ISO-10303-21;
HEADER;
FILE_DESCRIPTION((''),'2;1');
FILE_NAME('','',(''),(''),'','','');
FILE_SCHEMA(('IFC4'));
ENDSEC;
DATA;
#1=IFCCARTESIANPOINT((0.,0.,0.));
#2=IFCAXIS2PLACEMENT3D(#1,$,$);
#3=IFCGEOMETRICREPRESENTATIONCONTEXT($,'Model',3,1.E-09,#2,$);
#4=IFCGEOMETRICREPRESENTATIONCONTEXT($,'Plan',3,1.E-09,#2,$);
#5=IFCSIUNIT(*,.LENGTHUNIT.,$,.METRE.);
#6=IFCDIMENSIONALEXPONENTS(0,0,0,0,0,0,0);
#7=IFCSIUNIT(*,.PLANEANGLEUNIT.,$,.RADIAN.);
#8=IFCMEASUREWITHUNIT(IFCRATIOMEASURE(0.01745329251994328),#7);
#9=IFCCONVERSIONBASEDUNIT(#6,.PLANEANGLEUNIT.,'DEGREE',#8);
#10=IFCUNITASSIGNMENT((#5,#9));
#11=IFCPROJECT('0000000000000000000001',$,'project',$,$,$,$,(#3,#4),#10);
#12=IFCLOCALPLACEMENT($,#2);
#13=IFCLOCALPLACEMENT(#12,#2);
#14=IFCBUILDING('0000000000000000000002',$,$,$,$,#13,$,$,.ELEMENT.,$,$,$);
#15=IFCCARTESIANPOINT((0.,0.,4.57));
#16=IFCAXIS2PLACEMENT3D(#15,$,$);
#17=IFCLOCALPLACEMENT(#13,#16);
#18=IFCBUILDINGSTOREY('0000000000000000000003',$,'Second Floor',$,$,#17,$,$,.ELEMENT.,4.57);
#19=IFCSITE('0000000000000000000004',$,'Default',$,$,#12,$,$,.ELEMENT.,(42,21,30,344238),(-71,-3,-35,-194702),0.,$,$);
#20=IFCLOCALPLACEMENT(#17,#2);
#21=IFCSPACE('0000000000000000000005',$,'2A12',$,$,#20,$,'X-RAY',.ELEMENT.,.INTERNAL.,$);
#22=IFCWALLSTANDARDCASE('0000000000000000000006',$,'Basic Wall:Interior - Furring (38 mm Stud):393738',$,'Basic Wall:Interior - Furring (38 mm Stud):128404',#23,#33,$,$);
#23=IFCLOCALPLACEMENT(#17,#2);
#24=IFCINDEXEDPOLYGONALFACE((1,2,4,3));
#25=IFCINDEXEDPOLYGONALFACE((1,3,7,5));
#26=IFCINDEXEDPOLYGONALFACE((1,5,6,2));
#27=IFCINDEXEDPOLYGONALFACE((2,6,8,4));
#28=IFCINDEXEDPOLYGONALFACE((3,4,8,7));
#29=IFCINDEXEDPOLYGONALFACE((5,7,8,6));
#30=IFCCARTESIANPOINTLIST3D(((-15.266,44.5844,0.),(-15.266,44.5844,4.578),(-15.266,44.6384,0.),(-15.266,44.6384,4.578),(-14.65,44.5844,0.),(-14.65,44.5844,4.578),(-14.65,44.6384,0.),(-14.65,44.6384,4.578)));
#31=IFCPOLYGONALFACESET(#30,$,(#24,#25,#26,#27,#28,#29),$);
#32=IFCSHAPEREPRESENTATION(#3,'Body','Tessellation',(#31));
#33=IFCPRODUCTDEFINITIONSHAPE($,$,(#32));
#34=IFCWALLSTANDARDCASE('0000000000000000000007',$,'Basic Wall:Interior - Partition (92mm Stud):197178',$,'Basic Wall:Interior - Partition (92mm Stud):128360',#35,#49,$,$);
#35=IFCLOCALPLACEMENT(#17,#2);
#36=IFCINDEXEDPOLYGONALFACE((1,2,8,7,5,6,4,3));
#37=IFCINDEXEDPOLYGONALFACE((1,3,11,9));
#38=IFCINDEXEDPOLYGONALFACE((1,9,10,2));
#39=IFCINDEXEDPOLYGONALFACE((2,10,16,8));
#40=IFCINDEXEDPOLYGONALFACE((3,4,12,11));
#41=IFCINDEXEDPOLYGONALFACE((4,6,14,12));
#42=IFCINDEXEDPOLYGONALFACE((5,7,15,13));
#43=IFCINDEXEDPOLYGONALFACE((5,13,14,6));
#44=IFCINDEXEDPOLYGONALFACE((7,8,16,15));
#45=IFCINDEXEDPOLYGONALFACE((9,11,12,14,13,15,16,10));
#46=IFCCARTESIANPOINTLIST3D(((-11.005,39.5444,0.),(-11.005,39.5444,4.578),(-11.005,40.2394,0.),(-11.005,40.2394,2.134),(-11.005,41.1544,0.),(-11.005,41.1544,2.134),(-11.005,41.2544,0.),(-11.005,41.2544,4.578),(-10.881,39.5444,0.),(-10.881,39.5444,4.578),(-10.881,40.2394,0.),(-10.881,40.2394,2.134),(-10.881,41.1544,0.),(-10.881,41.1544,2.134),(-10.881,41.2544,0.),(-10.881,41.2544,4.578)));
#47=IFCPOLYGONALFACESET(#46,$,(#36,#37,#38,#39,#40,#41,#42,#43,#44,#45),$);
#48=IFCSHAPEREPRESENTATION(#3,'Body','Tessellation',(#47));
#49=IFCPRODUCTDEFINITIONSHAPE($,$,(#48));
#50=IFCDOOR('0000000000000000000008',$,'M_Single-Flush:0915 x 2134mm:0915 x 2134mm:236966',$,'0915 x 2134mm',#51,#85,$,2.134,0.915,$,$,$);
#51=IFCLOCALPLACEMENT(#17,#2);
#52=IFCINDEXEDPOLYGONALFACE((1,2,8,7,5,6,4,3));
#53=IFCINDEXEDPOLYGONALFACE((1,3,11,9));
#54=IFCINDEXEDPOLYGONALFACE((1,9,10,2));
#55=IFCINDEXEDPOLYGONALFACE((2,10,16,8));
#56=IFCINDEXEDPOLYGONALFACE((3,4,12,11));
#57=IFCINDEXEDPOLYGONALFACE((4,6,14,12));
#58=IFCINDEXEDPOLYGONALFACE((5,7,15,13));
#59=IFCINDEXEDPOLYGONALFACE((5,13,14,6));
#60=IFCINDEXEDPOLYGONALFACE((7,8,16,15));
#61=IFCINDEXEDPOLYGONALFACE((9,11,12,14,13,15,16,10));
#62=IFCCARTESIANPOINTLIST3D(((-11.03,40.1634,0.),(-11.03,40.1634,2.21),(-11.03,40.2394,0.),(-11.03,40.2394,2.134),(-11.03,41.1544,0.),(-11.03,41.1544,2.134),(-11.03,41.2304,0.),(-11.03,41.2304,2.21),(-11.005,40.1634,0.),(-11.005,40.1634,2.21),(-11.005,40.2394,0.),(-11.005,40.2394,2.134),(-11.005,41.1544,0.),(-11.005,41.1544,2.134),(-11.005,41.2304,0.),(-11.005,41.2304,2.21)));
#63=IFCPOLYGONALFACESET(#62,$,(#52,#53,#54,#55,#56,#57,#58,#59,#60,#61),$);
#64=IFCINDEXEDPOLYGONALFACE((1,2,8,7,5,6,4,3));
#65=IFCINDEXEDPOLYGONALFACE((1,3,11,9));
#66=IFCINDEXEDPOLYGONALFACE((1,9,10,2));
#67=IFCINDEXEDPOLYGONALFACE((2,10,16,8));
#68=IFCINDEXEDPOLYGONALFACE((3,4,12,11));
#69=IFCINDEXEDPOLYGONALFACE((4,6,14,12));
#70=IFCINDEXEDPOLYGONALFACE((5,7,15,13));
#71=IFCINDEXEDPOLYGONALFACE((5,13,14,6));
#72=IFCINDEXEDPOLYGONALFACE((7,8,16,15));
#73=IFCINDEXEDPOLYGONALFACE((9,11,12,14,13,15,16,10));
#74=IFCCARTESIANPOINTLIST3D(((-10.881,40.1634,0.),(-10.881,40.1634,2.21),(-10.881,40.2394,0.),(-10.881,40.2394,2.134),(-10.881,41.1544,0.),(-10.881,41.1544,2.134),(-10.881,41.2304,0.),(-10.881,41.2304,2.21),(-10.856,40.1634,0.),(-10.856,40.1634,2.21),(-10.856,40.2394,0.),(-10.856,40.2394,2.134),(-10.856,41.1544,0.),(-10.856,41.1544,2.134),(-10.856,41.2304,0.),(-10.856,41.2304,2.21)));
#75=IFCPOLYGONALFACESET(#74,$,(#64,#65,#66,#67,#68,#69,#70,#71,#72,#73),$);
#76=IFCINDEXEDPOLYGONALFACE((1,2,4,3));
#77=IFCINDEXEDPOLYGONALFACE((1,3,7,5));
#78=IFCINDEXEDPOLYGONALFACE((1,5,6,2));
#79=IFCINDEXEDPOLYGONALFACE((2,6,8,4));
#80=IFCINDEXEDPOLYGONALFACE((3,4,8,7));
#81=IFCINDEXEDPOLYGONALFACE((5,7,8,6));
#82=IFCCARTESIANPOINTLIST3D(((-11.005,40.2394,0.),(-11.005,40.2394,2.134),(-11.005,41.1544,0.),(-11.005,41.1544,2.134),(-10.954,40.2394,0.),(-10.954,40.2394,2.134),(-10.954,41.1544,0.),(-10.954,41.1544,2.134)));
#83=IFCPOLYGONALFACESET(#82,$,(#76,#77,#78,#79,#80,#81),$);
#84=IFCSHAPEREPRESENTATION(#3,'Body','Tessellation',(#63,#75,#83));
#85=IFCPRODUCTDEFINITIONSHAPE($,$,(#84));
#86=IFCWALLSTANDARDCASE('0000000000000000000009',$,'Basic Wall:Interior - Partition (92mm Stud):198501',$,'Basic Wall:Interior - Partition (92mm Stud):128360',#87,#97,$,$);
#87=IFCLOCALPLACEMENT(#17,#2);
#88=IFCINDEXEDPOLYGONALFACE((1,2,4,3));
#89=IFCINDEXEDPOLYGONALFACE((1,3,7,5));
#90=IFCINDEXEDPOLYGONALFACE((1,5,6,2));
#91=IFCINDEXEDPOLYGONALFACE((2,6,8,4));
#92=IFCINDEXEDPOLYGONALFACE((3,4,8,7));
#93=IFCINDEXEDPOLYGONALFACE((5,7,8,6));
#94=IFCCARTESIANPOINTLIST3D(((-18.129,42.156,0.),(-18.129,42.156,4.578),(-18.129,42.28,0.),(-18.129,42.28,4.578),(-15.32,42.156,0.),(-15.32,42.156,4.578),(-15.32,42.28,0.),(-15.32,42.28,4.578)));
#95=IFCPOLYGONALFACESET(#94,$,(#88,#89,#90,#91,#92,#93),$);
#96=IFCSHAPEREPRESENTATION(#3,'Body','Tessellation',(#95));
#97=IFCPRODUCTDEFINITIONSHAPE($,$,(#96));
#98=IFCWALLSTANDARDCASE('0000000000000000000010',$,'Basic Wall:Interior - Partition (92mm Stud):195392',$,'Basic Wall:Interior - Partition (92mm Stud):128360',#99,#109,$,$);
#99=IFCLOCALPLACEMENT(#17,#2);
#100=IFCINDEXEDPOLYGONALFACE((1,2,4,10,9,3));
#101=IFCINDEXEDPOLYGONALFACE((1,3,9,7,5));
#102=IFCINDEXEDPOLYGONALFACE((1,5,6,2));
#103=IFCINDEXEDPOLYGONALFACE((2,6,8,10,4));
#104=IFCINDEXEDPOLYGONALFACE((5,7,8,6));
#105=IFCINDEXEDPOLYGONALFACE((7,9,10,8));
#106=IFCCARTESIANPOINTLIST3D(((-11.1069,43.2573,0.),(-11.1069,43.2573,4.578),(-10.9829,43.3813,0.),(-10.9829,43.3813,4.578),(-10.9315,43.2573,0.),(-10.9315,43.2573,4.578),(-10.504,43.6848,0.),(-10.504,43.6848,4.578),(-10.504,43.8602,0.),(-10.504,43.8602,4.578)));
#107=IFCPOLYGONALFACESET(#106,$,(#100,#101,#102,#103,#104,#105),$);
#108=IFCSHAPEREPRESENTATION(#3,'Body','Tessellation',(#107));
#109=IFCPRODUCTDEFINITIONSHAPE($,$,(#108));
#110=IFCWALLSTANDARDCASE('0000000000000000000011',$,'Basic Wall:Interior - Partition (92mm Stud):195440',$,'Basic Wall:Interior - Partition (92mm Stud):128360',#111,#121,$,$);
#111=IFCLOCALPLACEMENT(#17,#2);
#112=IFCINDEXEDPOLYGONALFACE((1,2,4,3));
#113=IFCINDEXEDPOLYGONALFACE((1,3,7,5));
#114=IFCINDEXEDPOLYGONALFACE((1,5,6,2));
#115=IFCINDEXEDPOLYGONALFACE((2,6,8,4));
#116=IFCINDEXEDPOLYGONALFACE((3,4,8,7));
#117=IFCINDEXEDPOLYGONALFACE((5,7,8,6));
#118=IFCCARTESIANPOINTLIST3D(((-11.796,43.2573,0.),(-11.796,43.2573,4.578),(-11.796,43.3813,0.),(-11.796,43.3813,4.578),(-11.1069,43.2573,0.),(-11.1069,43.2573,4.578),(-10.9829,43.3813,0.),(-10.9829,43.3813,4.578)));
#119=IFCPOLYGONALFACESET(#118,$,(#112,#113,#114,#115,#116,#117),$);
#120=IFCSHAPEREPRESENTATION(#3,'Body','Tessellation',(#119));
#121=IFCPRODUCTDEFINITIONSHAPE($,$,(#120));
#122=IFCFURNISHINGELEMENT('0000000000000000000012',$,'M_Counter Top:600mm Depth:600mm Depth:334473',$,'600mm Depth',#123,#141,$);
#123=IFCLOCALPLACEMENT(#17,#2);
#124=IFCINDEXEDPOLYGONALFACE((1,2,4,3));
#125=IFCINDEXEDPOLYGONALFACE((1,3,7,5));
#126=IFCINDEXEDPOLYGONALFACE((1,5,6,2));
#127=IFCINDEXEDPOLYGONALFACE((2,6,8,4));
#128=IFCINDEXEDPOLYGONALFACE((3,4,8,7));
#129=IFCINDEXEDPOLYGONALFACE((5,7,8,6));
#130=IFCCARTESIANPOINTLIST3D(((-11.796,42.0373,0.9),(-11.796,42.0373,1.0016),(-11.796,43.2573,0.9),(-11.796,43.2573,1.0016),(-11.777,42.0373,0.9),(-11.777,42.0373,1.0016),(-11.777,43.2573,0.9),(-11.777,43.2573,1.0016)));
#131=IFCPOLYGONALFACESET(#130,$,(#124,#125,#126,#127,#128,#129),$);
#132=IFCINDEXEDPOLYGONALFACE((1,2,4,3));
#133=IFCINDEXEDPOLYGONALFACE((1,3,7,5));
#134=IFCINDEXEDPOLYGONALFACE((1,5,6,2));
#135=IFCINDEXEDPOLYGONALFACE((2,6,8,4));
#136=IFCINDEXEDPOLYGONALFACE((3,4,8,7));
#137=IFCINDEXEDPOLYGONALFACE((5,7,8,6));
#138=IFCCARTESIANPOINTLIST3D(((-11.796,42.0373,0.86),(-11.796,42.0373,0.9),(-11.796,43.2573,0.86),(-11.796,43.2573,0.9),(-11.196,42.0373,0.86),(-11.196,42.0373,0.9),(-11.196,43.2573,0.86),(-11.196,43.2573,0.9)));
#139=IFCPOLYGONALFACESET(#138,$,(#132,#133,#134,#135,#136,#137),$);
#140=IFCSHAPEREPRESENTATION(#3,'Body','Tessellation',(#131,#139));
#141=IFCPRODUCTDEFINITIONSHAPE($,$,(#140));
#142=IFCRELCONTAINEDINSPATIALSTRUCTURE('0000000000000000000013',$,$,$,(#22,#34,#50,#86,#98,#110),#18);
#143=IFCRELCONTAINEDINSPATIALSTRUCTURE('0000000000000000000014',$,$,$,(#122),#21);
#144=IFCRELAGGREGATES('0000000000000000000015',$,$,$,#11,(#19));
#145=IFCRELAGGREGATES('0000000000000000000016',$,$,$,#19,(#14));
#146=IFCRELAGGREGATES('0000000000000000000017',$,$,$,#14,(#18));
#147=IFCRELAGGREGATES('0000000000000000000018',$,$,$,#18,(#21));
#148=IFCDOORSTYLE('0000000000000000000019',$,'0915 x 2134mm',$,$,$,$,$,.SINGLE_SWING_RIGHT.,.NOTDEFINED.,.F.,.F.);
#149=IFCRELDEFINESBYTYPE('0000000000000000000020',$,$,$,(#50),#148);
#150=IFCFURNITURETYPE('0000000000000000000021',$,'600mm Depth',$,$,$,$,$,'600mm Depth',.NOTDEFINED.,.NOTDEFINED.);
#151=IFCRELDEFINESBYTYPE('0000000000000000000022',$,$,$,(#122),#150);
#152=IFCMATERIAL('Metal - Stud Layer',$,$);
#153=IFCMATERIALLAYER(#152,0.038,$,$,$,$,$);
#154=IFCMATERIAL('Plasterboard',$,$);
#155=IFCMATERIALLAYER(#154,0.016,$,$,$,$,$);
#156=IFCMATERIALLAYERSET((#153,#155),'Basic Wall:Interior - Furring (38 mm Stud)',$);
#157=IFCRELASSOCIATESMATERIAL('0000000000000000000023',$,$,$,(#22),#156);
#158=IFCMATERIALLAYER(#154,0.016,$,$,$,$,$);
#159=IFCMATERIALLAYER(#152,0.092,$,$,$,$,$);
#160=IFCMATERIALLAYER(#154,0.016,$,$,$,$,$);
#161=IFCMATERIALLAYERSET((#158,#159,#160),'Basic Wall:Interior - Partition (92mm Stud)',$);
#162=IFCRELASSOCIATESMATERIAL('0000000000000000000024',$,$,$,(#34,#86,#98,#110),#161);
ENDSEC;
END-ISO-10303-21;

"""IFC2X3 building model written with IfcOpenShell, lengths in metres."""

from ifc_helpers import new_model, entity, si_unit, converted_unit, frame, frame_2d, origin, origin_2d_with_axis, place, context, project, spatial, polyline, rectangle, outline, extrude, source, transform, mapped, material, layer, layer_set, layer_usage, type_object, type_shapes, element, fill, save


model = new_model("IFC2X3")

# Units and contexts
model_context = context("Model", 3, precision=1e-09, world=origin())
plan_context = context("Plan", 3, precision=1e-09, world=origin())
ifc_project = project(units=[si_unit("LENGTHUNIT", "METRE"), converted_unit("PLANEANGLEUNIT", "DEGREE", entity("IfcRatioMeasure", 0.01745329251994328), si_unit("PLANEANGLEUNIT", "RADIAN"), dimensions=[0, 0, 0, 0, 0, 0, 0])], contexts=[model_context, plan_context])

# Site, building, storey
site_placement = place(None, origin())
site = spatial("IfcSite", under=ifc_project, at=site_placement, Name="Default", CompositionType="ELEMENT", RefLatitude=(42, 21, 30, 344238), RefLongitude=(-71, -3, -35, -194702), RefElevation=0.0)
building_placement = place(site_placement, origin())
building = spatial("IfcBuilding", under=site, at=building_placement, CompositionType="ELEMENT")
storey_placement = place(building_placement, frame((0.0, 0.0, 4.57)))
storey = spatial("IfcBuildingStorey", under=building, at=storey_placement, Name="Second Floor", CompositionType="ELEMENT", Elevation=4.57)

# Shared definitions
ifc_material_1 = material(Name="Plasterboard")
ifc_layer_1 = layer(ifc_material_1, 0.016)
ifc_material_2 = material(Name="Metal - Stud Layer")
ifc_layer_2 = layer(ifc_material_2, 0.092)
ifc_layer_3 = layer(ifc_material_1, 0.016)
ifc_layer_set_1 = layer_set([ifc_layer_1, ifc_layer_2, ifc_layer_3], Name="Basic Wall:Interior - Partition (92mm Stud)")
ifc_layer_usage_1 = layer_usage(ifc_layer_set_1, "AXIS2", "NEGATIVE", 0.062)

# Shared definitions
ifc_layer_4 = layer(ifc_material_2, 0.038)
ifc_layer_5 = layer(ifc_material_1, 0.016)
ifc_layer_set_2 = layer_set([ifc_layer_4, ifc_layer_5], Name="Basic Wall:Interior - Furring (38 mm Stud)")
ifc_layer_usage_2 = layer_usage(ifc_layer_set_2, "AXIS2", "POSITIVE", -0.027)

# Shared definitions
door_style_1 = type_object("IfcDoorStyle", Name="0915 x 2134mm", ConstructionType="NOTDEFINED", OperationType="SINGLE_SWING_RIGHT", ParameterTakesPrecedence=False, Sizeable=False)
shared_shape_1 = source(origin(), model_context, "Body", "SweptSolid", [
    extrude(outline(polyline([(-0.5335, -1.124), (0.5335, -1.124), (0.5335, 1.086), (0.4575, 1.086), (0.4575, -1.048), (-0.4575, -1.048), (-0.4575, 1.086), (-0.5335, 1.086), (-0.5335, -1.124)])), frame((0.4575, 0.124, 1.086), z_axis=(0.0, 1.0, 0.0), x_axis=(1.0, 0.0, 0.0)), (0.0, 0.0, 1.0), 0.025),
    extrude(outline(polyline([(-1.124, -0.5335), (1.086, -0.5335), (1.086, -0.4575), (-1.048, -0.4575), (-1.048, 0.4575), (1.086, 0.4575), (1.086, 0.5335), (-1.124, 0.5335), (-1.124, -0.5335)])), frame((0.4575, -0.025, 1.086), z_axis=(0.0, 1.0, 0.0), x_axis=(0.0, 0.0, -1.0)), (0.0, 0.0, 1.0), 0.025),
    extrude(rectangle(XDim=0.051, YDim=0.915, at=origin_2d_with_axis()), frame((0.4575, 0.0985, 0.0), z_axis=(0.0, 0.0, 1.0), x_axis=(0.0, 1.0, 0.0)), (0.0, 0.0, 1.0), 2.134),
])
type_shapes(door_style_1, [shared_shape_1])

# Wall
wall_1_placement = place(storey_placement, frame((-14.65, 44.6114, 0.0), z_axis=(0.0, 0.0, 1.0), x_axis=(-1.0, 0.0, 0.0)))
element("IfcWallStandardCase", 1, at=wall_1_placement, inside=storey, material=ifc_layer_usage_2, Name="Basic Wall:Interior - Furring (38 mm Stud):393738", ObjectType="Basic Wall:Interior - Furring (38 mm Stud):128404", context=model_context, shape_type="SweptSolid", body=[
    extrude(rectangle(XDim=0.616, YDim=0.054, at=frame_2d((0.308, 0.0), x_axis=(-1.0, 0.0))), origin(), (0.0, 0.0, 1.0), 4.578),
])

# Wall, opening, door
wall_2_placement = place(storey_placement, frame((-10.943, 39.5444, 0.0), z_axis=(0.0, 0.0, 1.0), x_axis=(0.0, 1.0, 0.0)))
wall_2 = element("IfcWallStandardCase", 2, at=wall_2_placement, inside=storey, material=ifc_layer_usage_1, Name="Basic Wall:Interior - Partition (92mm Stud):197178", ObjectType="Basic Wall:Interior - Partition (92mm Stud):128360", context=model_context, shape_type="SweptSolid", body=[
    extrude(rectangle(XDim=1.71, YDim=0.124, at=frame_2d((0.855, 0.0), x_axis=(-1.0, 0.0))), origin(), (0.0, 0.0, 1.0), 4.578),
])
opening_1_placement = place(wall_2_placement, frame((0.695, -0.062, 0.0)))
opening_1 = element("IfcOpeningElement", 3, at=opening_1_placement, cuts=wall_2, ObjectType="Opening", context=model_context, shape_type="SweptSolid", body=[
    extrude(rectangle(XDim=0.915, YDim=2.134, at=frame_2d((1.067, 0.4575), x_axis=(0.0, 1.0))), frame((0.0, 0.0, 0.0), z_axis=(0.0, 1.0, 0.0), x_axis=(0.0, 0.0, 1.0)), (0.0, 0.0, 1.0), 0.124),
])
door_1_placement = place(opening_1_placement, origin())
door_1 = element("IfcDoor", 4, at=door_1_placement, inside=storey, type_object=door_style_1, Name="M_Single-Flush:0915 x 2134mm:0915 x 2134mm:236966", ObjectType="0915 x 2134mm", OverallHeight=2.134, OverallWidth=0.915, context=model_context, shape_type="MappedRepresentation", body=[
    mapped(shared_shape_1, transform((0.0, 0.0, 0.0), scale=1.0)),
])
fill(opening_1, door_1)

# Walls
wall_3_placement = place(storey_placement, frame((-15.32, 42.218, 0.0), z_axis=(0.0, 0.0, 1.0), x_axis=(-1.0, 0.0, 0.0)))
element("IfcWallStandardCase", 5, at=wall_3_placement, inside=storey, material=ifc_layer_usage_1, Name="Basic Wall:Interior - Partition (92mm Stud):198501", ObjectType="Basic Wall:Interior - Partition (92mm Stud):128360", context=model_context, shape_type="SweptSolid", body=[
    extrude(rectangle(XDim=2.809, YDim=0.124, at=frame_2d((1.4045, 0.0), x_axis=(-1.0, 0.0))), origin(), (0.0, 0.0, 1.0), 4.578),
])
wall_4_placement = place(storey_placement, frame((-10.4601, 43.8164, 0.0), z_axis=(0.0, 0.0, 1.0), x_axis=(-0.707107, -0.707107, 0.0)))
element("IfcWallStandardCase", 6, at=wall_4_placement, inside=storey, material=ifc_layer_usage_1, Name="Basic Wall:Interior - Partition (92mm Stud):195392", ObjectType="Basic Wall:Interior - Partition (92mm Stud):128360", context=model_context, shape_type="SweptSolid", body=[
    extrude(outline(polyline([(0.8526, -0.062), (0.7286, 0.062), (0.124, 0.062), (0.0, -0.062), (0.6773, -0.062), (0.8526, -0.062)])), origin(), (0.0, 0.0, 1.0), 4.578),
])
wall_5_placement = place(storey_placement, frame((-10.9829, 43.3193, 0.0), z_axis=(0.0, 0.0, 1.0), x_axis=(-1.0, 0.0, 0.0)))
element("IfcWallStandardCase", 7, at=wall_5_placement, inside=storey, material=ifc_layer_usage_1, Name="Basic Wall:Interior - Partition (92mm Stud):195440", ObjectType="Basic Wall:Interior - Partition (92mm Stud):128360", context=model_context, shape_type="SweptSolid", body=[
    extrude(outline(polyline([(0.8131, -0.062), (0.8131, 0.062), (0.124, 0.062), (0.0, -0.062), (0.8131, -0.062)])), origin(), (0.0, 0.0, 1.0), 4.578),
])

# Shared definitions
space_1_placement = place(storey_placement, origin())
space_1 = spatial("IfcSpace", under=storey, at=space_1_placement, Name="2A12", LongName="X-RAY", CompositionType="ELEMENT", InteriorOrExteriorSpace="INTERNAL")

# Furnishing element
furniture_type = type_object("IfcFurnitureType", Name="600mm Depth", ElementType="600mm Depth", AssemblyPlace="NOTDEFINED")
shared_shape_2 = source(origin(), model_context, "Body", "SweptSolid", [
    extrude(rectangle(XDim=0.0191, YDim=1.22, at=origin_2d_with_axis()), frame((-0.5905, -0.0095, 0.9), z_axis=(0.0, 0.0, 1.0), x_axis=(0.0, -1.0, 0.0)), (0.0, 0.0, 1.0), 0.1016),
    extrude(rectangle(XDim=1.22, YDim=0.6, at=origin_2d_with_axis()), frame((-0.5905, -0.3, 0.86), z_axis=(0.0, 0.0, 1.0), x_axis=(-1.0, 0.0, 0.0)), (0.0, 0.0, 1.0), 0.04),
])
type_shapes(furniture_type, [shared_shape_2])
furnishing_placement = place(space_1_placement, frame((-11.796, 43.2378, 0.0), z_axis=(0.0, 0.0, 1.0), x_axis=(0.0, 1.0, 0.0)))
element("IfcFurnishingElement", 8, at=furnishing_placement, inside=space_1, type_object=furniture_type, Name="M_Counter Top:600mm Depth:600mm Depth:334473", ObjectType="600mm Depth", context=model_context, shape_type="MappedRepresentation", body=[
    mapped(shared_shape_2, transform((0.0, 0.0, 0.0), scale=1.0)),
])

save(model, "model.ifc")
